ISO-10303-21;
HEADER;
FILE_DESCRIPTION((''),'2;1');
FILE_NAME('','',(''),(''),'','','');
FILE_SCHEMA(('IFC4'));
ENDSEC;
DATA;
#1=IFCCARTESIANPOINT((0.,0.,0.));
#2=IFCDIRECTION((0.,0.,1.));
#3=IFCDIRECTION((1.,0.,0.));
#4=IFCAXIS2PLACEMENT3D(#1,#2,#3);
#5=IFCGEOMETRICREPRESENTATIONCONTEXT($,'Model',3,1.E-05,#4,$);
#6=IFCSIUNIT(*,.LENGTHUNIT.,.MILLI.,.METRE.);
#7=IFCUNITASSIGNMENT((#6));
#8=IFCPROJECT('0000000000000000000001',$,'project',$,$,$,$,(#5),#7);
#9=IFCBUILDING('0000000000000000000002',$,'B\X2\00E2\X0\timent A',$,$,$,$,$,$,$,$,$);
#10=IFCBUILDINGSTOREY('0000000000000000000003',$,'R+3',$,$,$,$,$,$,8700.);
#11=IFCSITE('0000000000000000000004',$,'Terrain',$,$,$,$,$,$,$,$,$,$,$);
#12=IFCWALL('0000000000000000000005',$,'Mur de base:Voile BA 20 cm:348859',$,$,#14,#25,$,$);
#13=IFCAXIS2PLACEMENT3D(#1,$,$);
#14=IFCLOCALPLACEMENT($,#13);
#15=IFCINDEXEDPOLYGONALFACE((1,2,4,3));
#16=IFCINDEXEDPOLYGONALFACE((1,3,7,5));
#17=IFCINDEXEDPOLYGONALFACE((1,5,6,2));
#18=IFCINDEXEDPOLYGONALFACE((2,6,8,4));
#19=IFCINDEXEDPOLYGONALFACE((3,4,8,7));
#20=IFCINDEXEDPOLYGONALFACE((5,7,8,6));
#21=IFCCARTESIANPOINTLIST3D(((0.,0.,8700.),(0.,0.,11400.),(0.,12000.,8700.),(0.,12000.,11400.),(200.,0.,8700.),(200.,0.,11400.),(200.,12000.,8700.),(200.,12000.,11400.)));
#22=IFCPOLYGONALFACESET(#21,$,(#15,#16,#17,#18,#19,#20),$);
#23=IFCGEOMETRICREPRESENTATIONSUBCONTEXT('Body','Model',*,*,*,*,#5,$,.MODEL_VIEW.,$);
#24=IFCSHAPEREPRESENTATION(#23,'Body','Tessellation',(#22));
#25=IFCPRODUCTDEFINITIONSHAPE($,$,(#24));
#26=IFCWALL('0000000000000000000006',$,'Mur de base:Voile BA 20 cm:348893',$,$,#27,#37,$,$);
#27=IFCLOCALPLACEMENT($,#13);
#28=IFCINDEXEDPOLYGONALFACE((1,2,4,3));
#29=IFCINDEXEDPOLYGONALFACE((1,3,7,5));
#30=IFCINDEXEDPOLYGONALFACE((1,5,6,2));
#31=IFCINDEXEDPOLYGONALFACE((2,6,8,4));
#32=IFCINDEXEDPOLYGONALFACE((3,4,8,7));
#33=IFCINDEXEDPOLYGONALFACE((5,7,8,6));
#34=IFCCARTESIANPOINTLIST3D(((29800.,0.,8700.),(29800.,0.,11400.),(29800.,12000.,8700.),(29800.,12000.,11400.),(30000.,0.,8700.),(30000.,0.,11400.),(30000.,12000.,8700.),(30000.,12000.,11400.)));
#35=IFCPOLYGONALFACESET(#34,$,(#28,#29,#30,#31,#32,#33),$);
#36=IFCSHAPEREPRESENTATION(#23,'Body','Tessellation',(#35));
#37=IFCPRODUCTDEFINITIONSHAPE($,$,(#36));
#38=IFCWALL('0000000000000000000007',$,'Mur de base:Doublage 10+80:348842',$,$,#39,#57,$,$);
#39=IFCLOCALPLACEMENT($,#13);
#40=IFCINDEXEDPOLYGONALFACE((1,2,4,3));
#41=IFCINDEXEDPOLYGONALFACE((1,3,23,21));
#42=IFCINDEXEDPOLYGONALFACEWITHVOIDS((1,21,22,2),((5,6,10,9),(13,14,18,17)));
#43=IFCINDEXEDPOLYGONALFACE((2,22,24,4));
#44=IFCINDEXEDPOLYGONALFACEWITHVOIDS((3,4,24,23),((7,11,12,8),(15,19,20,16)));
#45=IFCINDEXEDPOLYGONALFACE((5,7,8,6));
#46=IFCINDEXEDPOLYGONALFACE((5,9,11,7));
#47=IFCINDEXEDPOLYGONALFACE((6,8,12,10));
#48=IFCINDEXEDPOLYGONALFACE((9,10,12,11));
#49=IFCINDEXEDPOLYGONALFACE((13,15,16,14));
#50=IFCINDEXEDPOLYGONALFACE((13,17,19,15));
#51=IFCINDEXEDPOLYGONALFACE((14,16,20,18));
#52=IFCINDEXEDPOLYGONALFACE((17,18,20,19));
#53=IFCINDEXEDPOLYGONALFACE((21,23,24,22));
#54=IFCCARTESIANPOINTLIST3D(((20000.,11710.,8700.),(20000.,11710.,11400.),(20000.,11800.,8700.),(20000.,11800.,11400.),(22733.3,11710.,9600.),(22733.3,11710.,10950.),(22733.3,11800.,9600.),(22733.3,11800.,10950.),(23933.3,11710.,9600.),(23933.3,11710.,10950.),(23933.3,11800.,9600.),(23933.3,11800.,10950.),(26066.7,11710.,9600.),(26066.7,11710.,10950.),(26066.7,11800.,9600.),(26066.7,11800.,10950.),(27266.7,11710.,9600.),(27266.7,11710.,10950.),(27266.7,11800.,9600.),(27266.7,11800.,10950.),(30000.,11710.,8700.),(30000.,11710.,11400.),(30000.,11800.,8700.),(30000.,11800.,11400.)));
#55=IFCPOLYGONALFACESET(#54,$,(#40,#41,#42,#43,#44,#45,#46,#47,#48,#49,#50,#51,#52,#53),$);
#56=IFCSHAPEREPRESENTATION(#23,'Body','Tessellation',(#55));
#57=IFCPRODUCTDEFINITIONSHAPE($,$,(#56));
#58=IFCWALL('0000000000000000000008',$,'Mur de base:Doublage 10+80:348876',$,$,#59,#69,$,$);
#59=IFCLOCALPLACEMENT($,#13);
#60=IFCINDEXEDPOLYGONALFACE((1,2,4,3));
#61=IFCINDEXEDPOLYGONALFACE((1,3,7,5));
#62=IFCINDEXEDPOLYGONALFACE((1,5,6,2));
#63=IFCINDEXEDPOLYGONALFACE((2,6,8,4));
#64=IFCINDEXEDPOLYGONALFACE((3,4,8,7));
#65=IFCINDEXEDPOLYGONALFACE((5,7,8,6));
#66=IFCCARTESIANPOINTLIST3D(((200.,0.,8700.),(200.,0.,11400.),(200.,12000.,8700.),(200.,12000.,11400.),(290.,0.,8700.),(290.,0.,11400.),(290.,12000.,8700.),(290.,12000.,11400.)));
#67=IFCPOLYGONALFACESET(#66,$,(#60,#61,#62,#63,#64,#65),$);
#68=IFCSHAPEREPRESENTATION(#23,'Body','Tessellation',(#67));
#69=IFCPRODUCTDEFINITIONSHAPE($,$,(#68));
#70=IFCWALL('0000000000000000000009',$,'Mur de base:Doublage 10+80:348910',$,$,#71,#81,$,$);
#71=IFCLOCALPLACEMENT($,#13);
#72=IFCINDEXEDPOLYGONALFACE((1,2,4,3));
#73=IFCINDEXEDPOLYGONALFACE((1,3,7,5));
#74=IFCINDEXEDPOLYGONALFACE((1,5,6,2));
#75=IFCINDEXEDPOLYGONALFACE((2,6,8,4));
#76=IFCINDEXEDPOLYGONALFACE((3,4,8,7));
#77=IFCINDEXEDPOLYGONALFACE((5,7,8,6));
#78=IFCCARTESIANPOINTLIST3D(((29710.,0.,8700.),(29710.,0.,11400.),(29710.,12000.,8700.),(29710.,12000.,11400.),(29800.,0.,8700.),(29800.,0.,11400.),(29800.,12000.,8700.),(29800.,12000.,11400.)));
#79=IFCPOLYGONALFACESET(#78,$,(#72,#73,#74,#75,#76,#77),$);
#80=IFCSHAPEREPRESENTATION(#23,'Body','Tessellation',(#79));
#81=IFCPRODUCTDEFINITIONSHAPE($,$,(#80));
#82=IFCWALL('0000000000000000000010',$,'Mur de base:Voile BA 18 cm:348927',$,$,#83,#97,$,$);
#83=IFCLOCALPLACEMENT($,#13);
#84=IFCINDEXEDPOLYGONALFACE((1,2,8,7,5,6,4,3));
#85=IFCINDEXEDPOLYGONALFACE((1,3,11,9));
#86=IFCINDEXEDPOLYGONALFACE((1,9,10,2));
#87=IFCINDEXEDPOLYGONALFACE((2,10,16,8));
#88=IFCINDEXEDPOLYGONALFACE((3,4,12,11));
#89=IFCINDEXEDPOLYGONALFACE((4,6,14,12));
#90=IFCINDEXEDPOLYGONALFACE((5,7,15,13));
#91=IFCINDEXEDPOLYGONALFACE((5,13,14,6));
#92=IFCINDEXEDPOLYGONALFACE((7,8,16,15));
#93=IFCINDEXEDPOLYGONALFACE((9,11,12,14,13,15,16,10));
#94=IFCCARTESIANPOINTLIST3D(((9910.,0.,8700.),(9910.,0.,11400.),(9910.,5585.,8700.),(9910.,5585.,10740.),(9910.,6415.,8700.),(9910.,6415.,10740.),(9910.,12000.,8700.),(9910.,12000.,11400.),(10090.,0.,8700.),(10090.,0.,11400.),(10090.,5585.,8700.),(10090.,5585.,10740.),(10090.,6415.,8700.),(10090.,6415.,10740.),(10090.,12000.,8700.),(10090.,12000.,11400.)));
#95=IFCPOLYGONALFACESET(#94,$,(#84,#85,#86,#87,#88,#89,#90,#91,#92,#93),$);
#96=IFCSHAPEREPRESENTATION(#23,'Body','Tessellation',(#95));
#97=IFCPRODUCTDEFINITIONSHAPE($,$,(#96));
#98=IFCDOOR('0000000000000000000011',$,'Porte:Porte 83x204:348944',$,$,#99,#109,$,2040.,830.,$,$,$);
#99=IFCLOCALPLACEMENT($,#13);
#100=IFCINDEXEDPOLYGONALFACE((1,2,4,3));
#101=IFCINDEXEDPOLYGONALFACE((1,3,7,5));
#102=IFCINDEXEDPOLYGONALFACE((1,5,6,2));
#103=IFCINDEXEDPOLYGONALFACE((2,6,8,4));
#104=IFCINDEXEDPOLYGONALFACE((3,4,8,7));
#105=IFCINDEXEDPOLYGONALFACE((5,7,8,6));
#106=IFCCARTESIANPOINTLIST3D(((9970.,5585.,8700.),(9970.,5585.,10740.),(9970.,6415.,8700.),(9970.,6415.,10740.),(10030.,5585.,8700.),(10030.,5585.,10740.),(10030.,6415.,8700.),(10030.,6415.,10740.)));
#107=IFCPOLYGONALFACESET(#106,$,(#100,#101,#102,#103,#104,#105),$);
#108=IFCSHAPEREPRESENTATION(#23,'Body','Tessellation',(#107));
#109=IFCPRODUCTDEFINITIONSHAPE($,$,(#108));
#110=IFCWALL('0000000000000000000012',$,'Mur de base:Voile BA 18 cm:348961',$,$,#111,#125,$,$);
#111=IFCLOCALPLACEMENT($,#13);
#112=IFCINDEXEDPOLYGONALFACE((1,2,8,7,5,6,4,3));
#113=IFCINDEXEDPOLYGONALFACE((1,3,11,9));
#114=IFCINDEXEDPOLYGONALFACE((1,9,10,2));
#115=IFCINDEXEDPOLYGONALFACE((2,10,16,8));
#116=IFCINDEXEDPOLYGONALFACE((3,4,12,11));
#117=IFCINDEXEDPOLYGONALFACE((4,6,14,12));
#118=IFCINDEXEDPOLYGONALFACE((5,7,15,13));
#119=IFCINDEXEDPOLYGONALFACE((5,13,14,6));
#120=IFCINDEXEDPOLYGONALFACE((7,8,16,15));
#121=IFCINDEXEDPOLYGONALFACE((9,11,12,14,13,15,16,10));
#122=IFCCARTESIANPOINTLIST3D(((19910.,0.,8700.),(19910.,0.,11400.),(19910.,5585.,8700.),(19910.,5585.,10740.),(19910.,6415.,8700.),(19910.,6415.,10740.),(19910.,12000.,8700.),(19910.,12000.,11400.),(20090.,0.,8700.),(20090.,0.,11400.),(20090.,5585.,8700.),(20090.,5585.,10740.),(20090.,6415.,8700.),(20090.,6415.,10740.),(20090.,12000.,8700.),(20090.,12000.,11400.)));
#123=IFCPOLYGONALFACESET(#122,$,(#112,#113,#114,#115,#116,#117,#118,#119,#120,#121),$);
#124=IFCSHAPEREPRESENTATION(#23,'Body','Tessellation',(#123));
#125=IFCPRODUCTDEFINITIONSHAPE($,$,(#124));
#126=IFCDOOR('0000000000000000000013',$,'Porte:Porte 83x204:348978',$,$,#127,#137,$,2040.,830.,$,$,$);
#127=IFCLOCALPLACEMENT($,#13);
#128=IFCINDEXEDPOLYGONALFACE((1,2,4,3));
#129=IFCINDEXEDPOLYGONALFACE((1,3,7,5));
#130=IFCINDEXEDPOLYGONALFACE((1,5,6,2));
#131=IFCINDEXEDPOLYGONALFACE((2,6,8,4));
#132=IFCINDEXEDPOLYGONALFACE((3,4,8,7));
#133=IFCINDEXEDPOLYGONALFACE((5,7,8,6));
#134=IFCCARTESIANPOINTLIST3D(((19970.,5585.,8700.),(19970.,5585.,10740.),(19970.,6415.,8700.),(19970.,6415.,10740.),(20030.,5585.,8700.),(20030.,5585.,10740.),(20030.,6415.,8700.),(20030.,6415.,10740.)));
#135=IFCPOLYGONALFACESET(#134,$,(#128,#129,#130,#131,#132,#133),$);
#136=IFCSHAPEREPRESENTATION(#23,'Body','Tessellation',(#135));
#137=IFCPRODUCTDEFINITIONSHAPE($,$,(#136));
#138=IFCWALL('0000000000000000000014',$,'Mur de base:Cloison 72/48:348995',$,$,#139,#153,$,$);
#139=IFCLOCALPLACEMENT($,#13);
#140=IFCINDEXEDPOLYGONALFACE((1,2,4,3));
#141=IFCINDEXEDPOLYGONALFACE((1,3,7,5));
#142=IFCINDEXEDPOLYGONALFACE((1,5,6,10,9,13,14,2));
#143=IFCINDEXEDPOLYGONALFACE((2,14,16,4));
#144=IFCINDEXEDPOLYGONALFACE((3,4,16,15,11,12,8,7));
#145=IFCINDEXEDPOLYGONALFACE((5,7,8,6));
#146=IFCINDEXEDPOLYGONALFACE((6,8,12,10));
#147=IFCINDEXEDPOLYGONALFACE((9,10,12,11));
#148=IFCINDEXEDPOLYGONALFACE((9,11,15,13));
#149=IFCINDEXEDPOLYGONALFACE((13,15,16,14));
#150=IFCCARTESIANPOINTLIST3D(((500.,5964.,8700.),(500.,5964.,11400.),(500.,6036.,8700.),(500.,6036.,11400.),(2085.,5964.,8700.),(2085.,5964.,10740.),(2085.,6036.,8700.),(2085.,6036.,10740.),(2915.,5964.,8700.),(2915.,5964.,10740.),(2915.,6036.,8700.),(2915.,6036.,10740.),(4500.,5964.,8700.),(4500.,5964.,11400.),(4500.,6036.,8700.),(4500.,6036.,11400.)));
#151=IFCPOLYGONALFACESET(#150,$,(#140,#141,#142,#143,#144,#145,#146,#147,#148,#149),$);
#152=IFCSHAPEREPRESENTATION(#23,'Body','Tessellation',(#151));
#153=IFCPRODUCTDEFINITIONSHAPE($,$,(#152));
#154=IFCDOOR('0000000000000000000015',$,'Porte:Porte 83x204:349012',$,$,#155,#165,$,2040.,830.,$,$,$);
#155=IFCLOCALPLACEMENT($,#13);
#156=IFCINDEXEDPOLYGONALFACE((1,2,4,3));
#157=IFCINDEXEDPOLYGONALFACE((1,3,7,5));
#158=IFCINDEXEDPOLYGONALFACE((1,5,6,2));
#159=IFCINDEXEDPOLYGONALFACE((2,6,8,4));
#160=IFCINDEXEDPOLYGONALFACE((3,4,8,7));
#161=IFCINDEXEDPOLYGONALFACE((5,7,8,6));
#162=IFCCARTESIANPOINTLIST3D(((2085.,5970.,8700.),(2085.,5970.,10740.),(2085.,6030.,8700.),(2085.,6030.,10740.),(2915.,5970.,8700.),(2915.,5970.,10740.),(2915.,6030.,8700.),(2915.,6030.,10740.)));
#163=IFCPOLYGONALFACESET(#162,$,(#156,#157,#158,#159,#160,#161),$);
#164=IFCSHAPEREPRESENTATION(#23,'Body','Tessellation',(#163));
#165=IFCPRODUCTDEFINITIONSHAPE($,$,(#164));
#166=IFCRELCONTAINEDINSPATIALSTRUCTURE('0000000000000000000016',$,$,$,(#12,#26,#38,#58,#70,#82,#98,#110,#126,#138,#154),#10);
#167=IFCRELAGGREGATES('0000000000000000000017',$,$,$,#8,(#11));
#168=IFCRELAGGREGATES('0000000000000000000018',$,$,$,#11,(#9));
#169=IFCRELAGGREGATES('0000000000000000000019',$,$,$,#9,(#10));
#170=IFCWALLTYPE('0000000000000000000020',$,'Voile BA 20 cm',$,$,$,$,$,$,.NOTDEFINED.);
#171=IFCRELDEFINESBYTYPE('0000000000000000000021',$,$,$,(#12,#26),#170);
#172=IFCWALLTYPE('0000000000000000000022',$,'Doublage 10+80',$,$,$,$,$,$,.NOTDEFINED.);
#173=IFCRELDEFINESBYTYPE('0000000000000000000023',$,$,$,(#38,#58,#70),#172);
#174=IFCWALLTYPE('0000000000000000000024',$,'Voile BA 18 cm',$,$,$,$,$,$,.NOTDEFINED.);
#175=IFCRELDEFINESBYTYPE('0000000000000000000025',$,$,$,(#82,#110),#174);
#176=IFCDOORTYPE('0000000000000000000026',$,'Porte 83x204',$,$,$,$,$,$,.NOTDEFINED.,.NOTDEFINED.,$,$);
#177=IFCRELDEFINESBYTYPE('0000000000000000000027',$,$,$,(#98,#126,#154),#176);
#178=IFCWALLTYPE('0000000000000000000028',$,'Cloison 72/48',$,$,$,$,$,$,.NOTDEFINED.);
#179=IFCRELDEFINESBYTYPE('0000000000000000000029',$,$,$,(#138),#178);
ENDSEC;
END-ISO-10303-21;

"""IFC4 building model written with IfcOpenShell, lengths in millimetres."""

from ifc_helpers import new_model, si_unit, frame, frame_2d, origin_with_axes, place, context, subcontext, project, spatial, rectangle, extrude, type_object, element, fill, save


model = new_model("IFC4")

# Units and contexts
model_context = context("Model", 3, precision=1e-05, world=origin_with_axes())
body_context = subcontext(model_context, "Body", "Model", "MODEL_VIEW")
ifc_project = project(units=[si_unit("LENGTHUNIT", "METRE", prefix="MILLI")], contexts=[model_context])

# Site, building, storey
site = spatial("IfcSite", under=ifc_project, Name="Terrain")
building = spatial("IfcBuilding", under=site, Name="Bâtiment A")
storey = spatial("IfcBuildingStorey", under=building, Name="R+3", Elevation=8700.0)

# Walls
wall_type_1 = type_object("IfcWallType", Name="Voile BA 20 cm", PredefinedType="NOTDEFINED")
wall_1_placement = place(None, origin_with_axes())
element("IfcWall", 1, at=wall_1_placement, inside=storey, type_object=wall_type_1, Name="Mur de base:Voile BA 20 cm:348859", context=body_context, shape_type="SweptSolid", body=[
    extrude(rectangle(XDim=200.0, YDim=12000.0, at=frame_2d((100.0, 6000.0))), frame((0.0, 0.0, 8700.0), z_axis=(0.0, 0.0, 1.0), x_axis=(1.0, 0.0, 0.0)), (0.0, 0.0, 1.0), 2700.0),
])
wall_2_placement = place(None, origin_with_axes())
element("IfcWall", 2, at=wall_2_placement, inside=storey, type_object=wall_type_1, Name="Mur de base:Voile BA 20 cm:348893", context=body_context, shape_type="SweptSolid", body=[
    extrude(rectangle(XDim=200.0, YDim=12000.0, at=frame_2d((29900.0, 6000.0))), frame((0.0, 0.0, 8700.0), z_axis=(0.0, 0.0, 1.0), x_axis=(1.0, 0.0, 0.0)), (0.0, 0.0, 1.0), 2700.0),
])

# Wall, openings
wall_type_2 = type_object("IfcWallType", Name="Doublage 10+80", PredefinedType="NOTDEFINED")
wall_3_placement = place(None, origin_with_axes())
wall_3 = element("IfcWall", 3, at=wall_3_placement, inside=storey, type_object=wall_type_2, Name="Mur de base:Doublage 10+80:348842", context=body_context, shape_type="SweptSolid", body=[
    extrude(rectangle(XDim=10000.0, YDim=90.0, at=frame_2d((25000.0, 11755.0))), frame((0.0, 0.0, 8700.0), z_axis=(0.0, 0.0, 1.0), x_axis=(1.0, 0.0, 0.0)), (0.0, 0.0, 1.0), 2700.0),
])
opening_1_placement = place(None, origin_with_axes())
element("IfcOpeningElement", 4, at=opening_1_placement, cuts=wall_3, context=body_context, shape_type="SweptSolid", body=[
    extrude(rectangle(XDim=1200.0, YDim=210.0, at=frame_2d((23333.3, 11755.0))), frame((0.0, 0.0, 9600.0), z_axis=(0.0, 0.0, 1.0), x_axis=(1.0, 0.0, 0.0)), (0.0, 0.0, 1.0), 1350.0),
])
opening_2_placement = place(None, origin_with_axes())
element("IfcOpeningElement", 5, at=opening_2_placement, cuts=wall_3, context=body_context, shape_type="SweptSolid", body=[
    extrude(rectangle(XDim=1200.0, YDim=210.0, at=frame_2d((26666.7, 11755.0))), frame((0.0, 0.0, 9600.0), z_axis=(0.0, 0.0, 1.0), x_axis=(1.0, 0.0, 0.0)), (0.0, 0.0, 1.0), 1350.0),
])

# Walls
wall_4_placement = place(None, origin_with_axes())
element("IfcWall", 6, at=wall_4_placement, inside=storey, type_object=wall_type_2, Name="Mur de base:Doublage 10+80:348876", context=body_context, shape_type="SweptSolid", body=[
    extrude(rectangle(XDim=90.0, YDim=12000.0, at=frame_2d((245.0, 6000.0))), frame((0.0, 0.0, 8700.0), z_axis=(0.0, 0.0, 1.0), x_axis=(1.0, 0.0, 0.0)), (0.0, 0.0, 1.0), 2700.0),
])
wall_5_placement = place(None, origin_with_axes())
element("IfcWall", 7, at=wall_5_placement, inside=storey, type_object=wall_type_2, Name="Mur de base:Doublage 10+80:348910", context=body_context, shape_type="SweptSolid", body=[
    extrude(rectangle(XDim=90.0, YDim=12000.0, at=frame_2d((29755.0, 6000.0))), frame((0.0, 0.0, 8700.0), z_axis=(0.0, 0.0, 1.0), x_axis=(1.0, 0.0, 0.0)), (0.0, 0.0, 1.0), 2700.0),
])

# Walls, openings, doors
wall_type_3 = type_object("IfcWallType", Name="Voile BA 18 cm", PredefinedType="NOTDEFINED")
wall_6_placement = place(None, origin_with_axes())
wall_6 = element("IfcWall", 8, at=wall_6_placement, inside=storey, type_object=wall_type_3, Name="Mur de base:Voile BA 18 cm:348927", context=body_context, shape_type="SweptSolid", body=[
    extrude(rectangle(XDim=180.0, YDim=12000.0, at=frame_2d((10000.0, 6000.0))), frame((0.0, 0.0, 8700.0), z_axis=(0.0, 0.0, 1.0), x_axis=(1.0, 0.0, 0.0)), (0.0, 0.0, 1.0), 2700.0),
])
opening_3_placement = place(None, origin_with_axes())
opening_3 = element("IfcOpeningElement", 9, at=opening_3_placement, cuts=wall_6, context=body_context, shape_type="SweptSolid", body=[
    extrude(rectangle(XDim=300.0, YDim=830.0, at=frame_2d((10000.0, 6000.0))), frame((0.0, 0.0, 8700.0), z_axis=(0.0, 0.0, 1.0), x_axis=(1.0, 0.0, 0.0)), (0.0, 0.0, 1.0), 2040.0),
])
door_type = type_object("IfcDoorType", Name="Porte 83x204", OperationType="NOTDEFINED", PredefinedType="NOTDEFINED")
door_1_placement = place(None, origin_with_axes())
door_1 = element("IfcDoor", 10, at=door_1_placement, inside=storey, type_object=door_type, Name="Porte:Porte 83x204:348944", OverallHeight=2040.0, OverallWidth=830.0, context=body_context, shape_type="SweptSolid", body=[
    extrude(rectangle(XDim=60.0, YDim=830.0, at=frame_2d((10000.0, 6000.0))), frame((0.0, 0.0, 8700.0), z_axis=(0.0, 0.0, 1.0), x_axis=(1.0, 0.0, 0.0)), (0.0, 0.0, 1.0), 2040.0),
])
fill(opening_3, door_1)
wall_7_placement = place(None, origin_with_axes())
wall_7 = element("IfcWall", 11, at=wall_7_placement, inside=storey, type_object=wall_type_3, Name="Mur de base:Voile BA 18 cm:348961", context=body_context, shape_type="SweptSolid", body=[
    extrude(rectangle(XDim=180.0, YDim=12000.0, at=frame_2d((20000.0, 6000.0))), frame((0.0, 0.0, 8700.0), z_axis=(0.0, 0.0, 1.0), x_axis=(1.0, 0.0, 0.0)), (0.0, 0.0, 1.0), 2700.0),
])
opening_4_placement = place(None, origin_with_axes())
opening_4 = element("IfcOpeningElement", 12, at=opening_4_placement, cuts=wall_7, context=body_context, shape_type="SweptSolid", body=[
    extrude(rectangle(XDim=300.0, YDim=830.0, at=frame_2d((20000.0, 6000.0))), frame((0.0, 0.0, 8700.0), z_axis=(0.0, 0.0, 1.0), x_axis=(1.0, 0.0, 0.0)), (0.0, 0.0, 1.0), 2040.0),
])
door_2_placement = place(None, origin_with_axes())
door_2 = element("IfcDoor", 13, at=door_2_placement, inside=storey, type_object=door_type, Name="Porte:Porte 83x204:348978", OverallHeight=2040.0, OverallWidth=830.0, context=body_context, shape_type="SweptSolid", body=[
    extrude(rectangle(XDim=60.0, YDim=830.0, at=frame_2d((20000.0, 6000.0))), frame((0.0, 0.0, 8700.0), z_axis=(0.0, 0.0, 1.0), x_axis=(1.0, 0.0, 0.0)), (0.0, 0.0, 1.0), 2040.0),
])
fill(opening_4, door_2)
wall_type_4 = type_object("IfcWallType", Name="Cloison 72/48", PredefinedType="NOTDEFINED")
wall_8_placement = place(None, origin_with_axes())
wall_8 = element("IfcWall", 14, at=wall_8_placement, inside=storey, type_object=wall_type_4, Name="Mur de base:Cloison 72/48:348995", context=body_context, shape_type="SweptSolid", body=[
    extrude(rectangle(XDim=4000.0, YDim=72.0, at=frame_2d((2500.0, 6000.0))), frame((0.0, 0.0, 8700.0), z_axis=(0.0, 0.0, 1.0), x_axis=(1.0, 0.0, 0.0)), (0.0, 0.0, 1.0), 2700.0),
])
opening_5_placement = place(None, origin_with_axes())
opening_5 = element("IfcOpeningElement", 15, at=opening_5_placement, cuts=wall_8, context=body_context, shape_type="SweptSolid", body=[
    extrude(rectangle(XDim=830.0, YDim=192.0, at=frame_2d((2500.0, 6000.0))), frame((0.0, 0.0, 8700.0), z_axis=(0.0, 0.0, 1.0), x_axis=(1.0, 0.0, 0.0)), (0.0, 0.0, 1.0), 2040.0),
])
door_3_placement = place(None, origin_with_axes())
door_3 = element("IfcDoor", 16, at=door_3_placement, inside=storey, type_object=door_type, Name="Porte:Porte 83x204:349012", OverallHeight=2040.0, OverallWidth=830.0, context=body_context, shape_type="SweptSolid", body=[
    extrude(rectangle(XDim=830.0, YDim=60.0, at=frame_2d((2500.0, 6000.0))), frame((0.0, 0.0, 8700.0), z_axis=(0.0, 0.0, 1.0), x_axis=(1.0, 0.0, 0.0)), (0.0, 0.0, 1.0), 2040.0),
])
fill(opening_5, door_3)

save(model, "model.ifc")
